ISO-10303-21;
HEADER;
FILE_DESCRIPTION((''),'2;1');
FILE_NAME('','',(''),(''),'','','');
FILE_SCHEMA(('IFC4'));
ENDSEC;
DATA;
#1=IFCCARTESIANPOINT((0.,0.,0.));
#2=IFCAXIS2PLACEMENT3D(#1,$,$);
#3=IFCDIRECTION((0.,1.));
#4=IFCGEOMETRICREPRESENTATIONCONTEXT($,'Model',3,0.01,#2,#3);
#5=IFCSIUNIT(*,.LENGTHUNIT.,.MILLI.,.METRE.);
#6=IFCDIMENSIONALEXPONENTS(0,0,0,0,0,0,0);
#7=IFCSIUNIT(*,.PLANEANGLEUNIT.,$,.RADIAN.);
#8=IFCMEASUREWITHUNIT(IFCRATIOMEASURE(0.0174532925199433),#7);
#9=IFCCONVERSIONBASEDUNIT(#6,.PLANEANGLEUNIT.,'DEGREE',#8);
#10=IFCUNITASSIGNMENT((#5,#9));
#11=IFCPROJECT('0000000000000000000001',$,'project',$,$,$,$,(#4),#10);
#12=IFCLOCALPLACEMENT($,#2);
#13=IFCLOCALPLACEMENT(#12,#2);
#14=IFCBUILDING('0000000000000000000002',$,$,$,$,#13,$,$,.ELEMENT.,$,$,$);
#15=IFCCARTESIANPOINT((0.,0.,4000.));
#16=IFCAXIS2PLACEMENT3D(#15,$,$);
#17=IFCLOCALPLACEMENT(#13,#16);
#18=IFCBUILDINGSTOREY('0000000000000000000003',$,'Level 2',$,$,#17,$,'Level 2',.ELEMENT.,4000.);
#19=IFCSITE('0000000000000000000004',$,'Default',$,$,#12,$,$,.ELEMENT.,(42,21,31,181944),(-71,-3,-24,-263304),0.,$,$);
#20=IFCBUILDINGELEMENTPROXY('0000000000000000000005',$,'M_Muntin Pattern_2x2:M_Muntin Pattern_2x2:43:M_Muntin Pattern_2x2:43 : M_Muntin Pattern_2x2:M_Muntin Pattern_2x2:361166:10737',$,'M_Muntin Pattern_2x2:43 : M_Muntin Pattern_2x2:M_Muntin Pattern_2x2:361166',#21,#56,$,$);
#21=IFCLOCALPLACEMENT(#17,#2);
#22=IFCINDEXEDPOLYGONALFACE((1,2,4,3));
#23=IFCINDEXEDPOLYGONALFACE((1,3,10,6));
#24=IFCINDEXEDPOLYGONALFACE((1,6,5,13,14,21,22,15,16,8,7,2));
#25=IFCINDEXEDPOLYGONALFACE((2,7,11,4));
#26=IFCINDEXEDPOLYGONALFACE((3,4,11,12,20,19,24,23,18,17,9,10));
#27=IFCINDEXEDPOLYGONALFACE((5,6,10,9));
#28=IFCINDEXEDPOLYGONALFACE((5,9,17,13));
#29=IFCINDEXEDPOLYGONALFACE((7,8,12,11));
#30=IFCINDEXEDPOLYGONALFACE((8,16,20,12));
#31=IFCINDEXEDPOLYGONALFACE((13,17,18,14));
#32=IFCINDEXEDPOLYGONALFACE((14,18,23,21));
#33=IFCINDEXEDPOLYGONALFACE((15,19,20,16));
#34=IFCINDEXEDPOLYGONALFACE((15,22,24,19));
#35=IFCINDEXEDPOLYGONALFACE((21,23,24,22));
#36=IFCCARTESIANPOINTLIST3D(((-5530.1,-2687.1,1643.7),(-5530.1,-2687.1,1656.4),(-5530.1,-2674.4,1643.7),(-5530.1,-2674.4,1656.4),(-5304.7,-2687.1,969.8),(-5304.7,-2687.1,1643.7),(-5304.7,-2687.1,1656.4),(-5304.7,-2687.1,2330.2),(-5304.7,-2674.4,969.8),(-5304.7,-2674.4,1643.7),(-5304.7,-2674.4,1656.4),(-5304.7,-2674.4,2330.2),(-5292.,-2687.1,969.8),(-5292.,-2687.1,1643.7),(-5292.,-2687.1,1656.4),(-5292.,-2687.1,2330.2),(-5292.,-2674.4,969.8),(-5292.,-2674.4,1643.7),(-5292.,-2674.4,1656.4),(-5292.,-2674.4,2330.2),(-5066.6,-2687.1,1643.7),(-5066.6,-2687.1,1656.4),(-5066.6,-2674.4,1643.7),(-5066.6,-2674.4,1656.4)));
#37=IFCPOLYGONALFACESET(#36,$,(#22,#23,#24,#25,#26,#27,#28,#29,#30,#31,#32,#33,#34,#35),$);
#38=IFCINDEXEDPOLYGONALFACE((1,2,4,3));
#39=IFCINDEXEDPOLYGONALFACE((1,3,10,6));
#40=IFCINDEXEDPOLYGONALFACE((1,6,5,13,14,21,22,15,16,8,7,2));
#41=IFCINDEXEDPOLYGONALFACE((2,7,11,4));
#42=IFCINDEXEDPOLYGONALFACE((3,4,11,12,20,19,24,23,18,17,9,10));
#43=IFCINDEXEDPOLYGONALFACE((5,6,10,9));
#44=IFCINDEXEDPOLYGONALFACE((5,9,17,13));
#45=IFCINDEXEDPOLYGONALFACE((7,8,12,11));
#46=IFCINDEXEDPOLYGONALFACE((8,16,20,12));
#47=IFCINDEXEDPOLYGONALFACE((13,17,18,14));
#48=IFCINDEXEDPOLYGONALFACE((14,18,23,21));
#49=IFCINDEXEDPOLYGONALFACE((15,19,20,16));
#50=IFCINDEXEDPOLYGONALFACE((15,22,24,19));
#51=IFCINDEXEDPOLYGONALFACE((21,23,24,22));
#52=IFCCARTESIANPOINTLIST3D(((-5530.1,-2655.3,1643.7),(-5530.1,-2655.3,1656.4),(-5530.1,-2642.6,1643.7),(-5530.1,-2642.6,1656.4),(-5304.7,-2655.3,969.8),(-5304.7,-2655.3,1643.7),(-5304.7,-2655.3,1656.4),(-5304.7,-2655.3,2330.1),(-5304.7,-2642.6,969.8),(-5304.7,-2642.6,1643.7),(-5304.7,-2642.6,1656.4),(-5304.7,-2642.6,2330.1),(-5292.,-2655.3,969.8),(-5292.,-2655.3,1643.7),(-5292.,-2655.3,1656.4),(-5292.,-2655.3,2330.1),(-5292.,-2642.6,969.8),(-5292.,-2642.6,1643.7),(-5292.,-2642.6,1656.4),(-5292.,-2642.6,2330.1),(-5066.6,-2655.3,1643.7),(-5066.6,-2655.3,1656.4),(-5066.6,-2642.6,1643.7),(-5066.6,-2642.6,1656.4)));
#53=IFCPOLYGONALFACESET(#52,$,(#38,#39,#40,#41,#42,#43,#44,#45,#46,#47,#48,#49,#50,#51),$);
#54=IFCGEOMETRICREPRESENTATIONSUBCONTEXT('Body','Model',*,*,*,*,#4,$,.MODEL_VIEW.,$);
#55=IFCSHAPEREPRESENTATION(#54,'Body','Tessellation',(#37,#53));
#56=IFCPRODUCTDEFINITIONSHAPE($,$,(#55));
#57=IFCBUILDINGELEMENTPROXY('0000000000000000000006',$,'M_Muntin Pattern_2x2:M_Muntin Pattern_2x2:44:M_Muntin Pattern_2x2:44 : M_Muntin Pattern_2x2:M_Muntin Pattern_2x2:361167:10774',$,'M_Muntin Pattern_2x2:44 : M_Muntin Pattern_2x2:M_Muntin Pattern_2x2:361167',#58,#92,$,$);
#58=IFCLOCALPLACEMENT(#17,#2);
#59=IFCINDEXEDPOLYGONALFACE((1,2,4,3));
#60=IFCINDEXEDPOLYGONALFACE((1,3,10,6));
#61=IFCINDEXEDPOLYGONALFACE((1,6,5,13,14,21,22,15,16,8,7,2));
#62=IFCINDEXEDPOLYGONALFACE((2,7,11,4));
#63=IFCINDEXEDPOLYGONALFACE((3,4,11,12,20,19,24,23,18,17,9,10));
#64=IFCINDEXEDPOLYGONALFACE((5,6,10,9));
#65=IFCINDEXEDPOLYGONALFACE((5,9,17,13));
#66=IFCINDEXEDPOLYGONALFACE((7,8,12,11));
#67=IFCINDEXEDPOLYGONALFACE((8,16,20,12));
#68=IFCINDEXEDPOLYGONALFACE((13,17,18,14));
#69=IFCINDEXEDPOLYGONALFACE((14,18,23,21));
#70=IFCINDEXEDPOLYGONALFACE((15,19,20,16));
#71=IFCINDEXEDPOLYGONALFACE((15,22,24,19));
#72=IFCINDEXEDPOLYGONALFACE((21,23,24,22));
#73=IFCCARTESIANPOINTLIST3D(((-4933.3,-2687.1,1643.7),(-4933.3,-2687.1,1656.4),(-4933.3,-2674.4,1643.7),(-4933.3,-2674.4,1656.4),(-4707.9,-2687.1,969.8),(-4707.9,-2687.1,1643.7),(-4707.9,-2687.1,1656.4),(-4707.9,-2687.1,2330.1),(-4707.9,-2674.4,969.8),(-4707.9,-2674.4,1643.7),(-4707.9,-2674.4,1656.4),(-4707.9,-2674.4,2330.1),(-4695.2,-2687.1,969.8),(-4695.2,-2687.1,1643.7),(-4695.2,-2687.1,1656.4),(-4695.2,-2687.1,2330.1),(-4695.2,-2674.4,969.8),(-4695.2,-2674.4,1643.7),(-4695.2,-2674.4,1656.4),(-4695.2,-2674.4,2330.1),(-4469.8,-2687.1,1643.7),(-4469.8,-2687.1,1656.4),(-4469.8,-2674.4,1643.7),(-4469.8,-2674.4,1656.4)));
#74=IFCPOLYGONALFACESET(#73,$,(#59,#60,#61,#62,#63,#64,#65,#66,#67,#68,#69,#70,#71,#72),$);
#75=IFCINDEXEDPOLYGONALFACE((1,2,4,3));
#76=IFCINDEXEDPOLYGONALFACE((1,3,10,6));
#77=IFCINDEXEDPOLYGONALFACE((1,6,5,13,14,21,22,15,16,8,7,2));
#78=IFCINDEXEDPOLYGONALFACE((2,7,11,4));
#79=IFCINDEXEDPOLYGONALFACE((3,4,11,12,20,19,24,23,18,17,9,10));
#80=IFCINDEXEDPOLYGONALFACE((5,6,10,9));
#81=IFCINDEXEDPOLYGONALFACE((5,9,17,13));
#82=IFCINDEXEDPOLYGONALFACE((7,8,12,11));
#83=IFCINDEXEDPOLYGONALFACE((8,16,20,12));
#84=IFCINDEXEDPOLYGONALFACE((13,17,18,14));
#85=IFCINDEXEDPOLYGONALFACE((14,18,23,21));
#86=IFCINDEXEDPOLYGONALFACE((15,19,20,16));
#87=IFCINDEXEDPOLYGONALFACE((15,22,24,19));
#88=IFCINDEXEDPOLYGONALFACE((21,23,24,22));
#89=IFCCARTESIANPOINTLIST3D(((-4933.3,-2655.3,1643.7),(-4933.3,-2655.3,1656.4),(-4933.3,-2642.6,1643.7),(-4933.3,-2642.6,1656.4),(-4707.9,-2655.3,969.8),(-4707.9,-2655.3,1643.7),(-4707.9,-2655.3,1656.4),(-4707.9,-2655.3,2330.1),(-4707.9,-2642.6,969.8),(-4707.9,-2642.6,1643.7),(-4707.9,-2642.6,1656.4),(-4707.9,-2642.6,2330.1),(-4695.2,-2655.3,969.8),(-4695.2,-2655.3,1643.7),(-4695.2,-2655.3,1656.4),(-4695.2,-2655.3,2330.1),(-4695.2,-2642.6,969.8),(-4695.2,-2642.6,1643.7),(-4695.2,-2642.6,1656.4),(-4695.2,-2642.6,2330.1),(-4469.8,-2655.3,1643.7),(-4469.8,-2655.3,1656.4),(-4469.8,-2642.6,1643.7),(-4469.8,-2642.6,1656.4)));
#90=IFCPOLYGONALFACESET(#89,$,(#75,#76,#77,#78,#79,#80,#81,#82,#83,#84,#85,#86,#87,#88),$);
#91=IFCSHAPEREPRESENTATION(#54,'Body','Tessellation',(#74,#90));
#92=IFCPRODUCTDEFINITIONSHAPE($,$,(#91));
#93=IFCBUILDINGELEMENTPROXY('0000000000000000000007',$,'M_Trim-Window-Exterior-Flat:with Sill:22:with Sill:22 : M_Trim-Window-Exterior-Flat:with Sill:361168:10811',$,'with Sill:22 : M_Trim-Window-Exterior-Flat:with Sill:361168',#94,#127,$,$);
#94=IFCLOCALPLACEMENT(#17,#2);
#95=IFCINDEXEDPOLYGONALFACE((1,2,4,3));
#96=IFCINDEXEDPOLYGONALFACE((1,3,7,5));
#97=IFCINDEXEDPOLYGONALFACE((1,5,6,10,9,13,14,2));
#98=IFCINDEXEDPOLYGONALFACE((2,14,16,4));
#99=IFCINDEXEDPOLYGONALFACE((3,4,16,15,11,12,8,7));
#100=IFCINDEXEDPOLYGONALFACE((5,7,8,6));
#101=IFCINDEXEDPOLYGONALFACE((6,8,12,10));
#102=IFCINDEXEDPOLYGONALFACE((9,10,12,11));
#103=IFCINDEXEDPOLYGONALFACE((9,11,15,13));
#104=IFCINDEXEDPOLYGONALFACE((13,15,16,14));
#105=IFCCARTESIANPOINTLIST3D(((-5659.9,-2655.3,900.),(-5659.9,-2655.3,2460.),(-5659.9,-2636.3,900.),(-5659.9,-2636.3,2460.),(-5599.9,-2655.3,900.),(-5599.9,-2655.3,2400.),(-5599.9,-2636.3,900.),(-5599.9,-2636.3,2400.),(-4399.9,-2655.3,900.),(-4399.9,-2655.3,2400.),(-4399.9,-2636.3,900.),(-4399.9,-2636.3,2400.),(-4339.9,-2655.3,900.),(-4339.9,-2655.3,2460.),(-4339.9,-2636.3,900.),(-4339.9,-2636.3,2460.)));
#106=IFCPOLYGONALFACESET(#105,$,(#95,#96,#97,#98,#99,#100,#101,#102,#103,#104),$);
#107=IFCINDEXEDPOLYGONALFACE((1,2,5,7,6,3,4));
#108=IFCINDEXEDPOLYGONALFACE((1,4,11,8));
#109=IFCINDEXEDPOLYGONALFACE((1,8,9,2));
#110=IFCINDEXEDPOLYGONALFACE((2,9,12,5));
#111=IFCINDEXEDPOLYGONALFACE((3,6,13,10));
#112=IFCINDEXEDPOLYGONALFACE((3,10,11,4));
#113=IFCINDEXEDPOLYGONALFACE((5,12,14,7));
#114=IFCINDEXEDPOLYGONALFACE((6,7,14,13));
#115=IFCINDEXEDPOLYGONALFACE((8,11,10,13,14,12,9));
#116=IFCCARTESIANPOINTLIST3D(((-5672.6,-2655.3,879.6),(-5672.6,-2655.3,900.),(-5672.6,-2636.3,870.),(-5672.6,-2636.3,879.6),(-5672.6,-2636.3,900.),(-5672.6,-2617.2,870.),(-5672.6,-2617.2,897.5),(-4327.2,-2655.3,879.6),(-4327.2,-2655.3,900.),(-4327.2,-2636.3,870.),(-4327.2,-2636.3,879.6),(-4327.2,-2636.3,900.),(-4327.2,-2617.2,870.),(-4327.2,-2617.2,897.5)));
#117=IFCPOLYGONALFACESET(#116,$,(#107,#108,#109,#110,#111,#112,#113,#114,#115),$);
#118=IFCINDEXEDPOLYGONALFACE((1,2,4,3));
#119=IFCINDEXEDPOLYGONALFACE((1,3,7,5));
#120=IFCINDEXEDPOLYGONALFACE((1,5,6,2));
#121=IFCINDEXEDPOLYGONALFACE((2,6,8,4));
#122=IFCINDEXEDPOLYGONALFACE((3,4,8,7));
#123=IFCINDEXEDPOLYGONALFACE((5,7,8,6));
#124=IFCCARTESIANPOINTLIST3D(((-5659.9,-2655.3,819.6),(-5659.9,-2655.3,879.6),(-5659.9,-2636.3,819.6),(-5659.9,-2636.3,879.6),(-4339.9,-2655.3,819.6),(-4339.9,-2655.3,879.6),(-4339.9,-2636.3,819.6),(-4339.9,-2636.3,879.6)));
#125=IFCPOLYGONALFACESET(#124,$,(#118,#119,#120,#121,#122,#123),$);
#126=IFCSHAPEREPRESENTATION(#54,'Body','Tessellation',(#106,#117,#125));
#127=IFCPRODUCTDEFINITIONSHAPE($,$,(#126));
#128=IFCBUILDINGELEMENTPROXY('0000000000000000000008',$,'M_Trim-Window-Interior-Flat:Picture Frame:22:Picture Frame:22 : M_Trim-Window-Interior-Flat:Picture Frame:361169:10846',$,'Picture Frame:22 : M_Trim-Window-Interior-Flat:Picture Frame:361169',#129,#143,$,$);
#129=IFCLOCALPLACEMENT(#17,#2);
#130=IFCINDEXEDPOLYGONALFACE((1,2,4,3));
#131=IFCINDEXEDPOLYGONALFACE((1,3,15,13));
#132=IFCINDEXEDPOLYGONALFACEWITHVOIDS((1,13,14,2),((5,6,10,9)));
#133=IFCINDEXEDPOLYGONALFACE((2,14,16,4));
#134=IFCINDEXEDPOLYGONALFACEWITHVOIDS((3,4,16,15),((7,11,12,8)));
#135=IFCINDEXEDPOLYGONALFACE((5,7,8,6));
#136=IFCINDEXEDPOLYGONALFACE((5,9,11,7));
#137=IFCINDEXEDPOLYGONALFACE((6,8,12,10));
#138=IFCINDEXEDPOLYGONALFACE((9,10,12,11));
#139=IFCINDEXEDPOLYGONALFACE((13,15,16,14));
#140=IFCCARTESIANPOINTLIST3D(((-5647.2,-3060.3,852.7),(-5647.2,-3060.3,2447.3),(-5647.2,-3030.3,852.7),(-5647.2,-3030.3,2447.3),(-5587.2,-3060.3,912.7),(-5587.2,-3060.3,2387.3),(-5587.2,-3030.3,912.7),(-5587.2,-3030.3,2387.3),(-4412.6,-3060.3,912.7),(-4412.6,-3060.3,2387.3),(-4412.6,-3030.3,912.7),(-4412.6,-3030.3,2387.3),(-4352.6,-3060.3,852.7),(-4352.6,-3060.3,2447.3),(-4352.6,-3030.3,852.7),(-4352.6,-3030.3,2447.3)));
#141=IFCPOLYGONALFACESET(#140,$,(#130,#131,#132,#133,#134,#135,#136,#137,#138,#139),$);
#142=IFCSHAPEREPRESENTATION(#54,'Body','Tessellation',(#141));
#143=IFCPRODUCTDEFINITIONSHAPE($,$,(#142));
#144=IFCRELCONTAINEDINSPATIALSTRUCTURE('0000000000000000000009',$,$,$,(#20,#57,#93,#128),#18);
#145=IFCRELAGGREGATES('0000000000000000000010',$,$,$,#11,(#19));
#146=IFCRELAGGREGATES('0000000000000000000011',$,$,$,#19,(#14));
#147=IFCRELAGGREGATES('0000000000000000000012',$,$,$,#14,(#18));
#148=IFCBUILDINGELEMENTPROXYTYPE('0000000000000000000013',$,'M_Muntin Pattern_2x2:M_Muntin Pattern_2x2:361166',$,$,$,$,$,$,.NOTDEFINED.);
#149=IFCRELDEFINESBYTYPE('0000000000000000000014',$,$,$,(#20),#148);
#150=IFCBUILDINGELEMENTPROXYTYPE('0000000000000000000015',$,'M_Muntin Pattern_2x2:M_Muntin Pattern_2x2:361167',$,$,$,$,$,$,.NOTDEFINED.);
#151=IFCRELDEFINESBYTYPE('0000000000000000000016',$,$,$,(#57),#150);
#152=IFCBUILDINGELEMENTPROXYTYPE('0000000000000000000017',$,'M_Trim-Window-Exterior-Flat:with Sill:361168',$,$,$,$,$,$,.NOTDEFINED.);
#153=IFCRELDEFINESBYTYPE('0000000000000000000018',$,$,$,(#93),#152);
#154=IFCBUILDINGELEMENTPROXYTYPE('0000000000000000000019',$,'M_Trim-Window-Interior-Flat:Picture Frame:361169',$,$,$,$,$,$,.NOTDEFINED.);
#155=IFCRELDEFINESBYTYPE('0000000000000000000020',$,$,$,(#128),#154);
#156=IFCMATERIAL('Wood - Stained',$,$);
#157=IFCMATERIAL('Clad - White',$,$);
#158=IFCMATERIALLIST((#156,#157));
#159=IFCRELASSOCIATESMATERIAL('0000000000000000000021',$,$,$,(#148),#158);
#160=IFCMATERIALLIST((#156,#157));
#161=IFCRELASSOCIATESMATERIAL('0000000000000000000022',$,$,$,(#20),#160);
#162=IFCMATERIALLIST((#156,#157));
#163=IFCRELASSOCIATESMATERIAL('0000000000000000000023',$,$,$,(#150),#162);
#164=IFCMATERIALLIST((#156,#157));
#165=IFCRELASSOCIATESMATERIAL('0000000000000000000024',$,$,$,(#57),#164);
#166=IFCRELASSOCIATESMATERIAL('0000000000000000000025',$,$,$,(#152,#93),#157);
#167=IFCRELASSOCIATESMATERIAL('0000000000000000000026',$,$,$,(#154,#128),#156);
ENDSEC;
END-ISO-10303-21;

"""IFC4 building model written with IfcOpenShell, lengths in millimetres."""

from ifc_helpers import new_model, entity, si_unit, converted_unit, direction, frame, frame_2d, origin, place, context, subcontext, project, spatial, polyline, rectangle, outline, extrude, source, transform, mapped, material, material_list, type_object, type_shapes, element, save


model = new_model("IFC4")

# Units and contexts
model_context = context("Model", 3, precision=0.01, world=origin(), true_north=direction((0.0, 1.0)))
body_context = subcontext(model_context, "Body", "Model", "MODEL_VIEW")
ifc_project = project(units=[si_unit("LENGTHUNIT", "METRE", prefix="MILLI"), converted_unit("PLANEANGLEUNIT", "DEGREE", entity("IfcRatioMeasure", 0.0174532925199433), si_unit("PLANEANGLEUNIT", "RADIAN"), dimensions=[0, 0, 0, 0, 0, 0, 0])], contexts=[model_context])

# Site, building, storey
site_placement = place(None, origin())
site = spatial("IfcSite", under=ifc_project, at=site_placement, Name="Default", CompositionType="ELEMENT", RefLatitude=(42, 21, 31, 181944), RefLongitude=(-71, -3, -24, -263304), RefElevation=0.0)
building_placement = place(site_placement, origin())
building = spatial("IfcBuilding", under=site, at=building_placement, CompositionType="ELEMENT")
storey_placement = place(building_placement, frame((0.0, 0.0, 4000.0)))
storey = spatial("IfcBuildingStorey", under=building, at=storey_placement, Name="Level 2", LongName="Level 2", CompositionType="ELEMENT", Elevation=4000.0)

# Building element proxies
ifc_material_1 = material(Name="Wood - Stained")
ifc_material_2 = material(Name="Clad - White")
ifc_material_list_1 = material_list([ifc_material_1, ifc_material_2])
ifc_material_list_2 = material_list([ifc_material_1, ifc_material_2])
building_element_proxy_type_1 = type_object("IfcBuildingElementProxyType", Name="M_Muntin Pattern_2x2:M_Muntin Pattern_2x2:361166", PredefinedType="NOTDEFINED", material=ifc_material_list_2)
shared_shape_1 = source(origin(), body_context, "Body", "SweptSolid", [
    extrude(outline(polyline([(-6.4, -680.2), (6.3, -680.2), (6.3, -6.4), (231.7, -6.4), (231.7, 6.3), (6.3, 6.3), (6.3, 680.2), (-6.4, 680.2), (-6.4, 6.3), (-231.7, 6.3), (-231.7, -6.4), (-6.4, -6.4), (-6.4, -680.2)])), frame((-5298.4, -2687.1, 5650.0), z_axis=(0.0, 1.0, 0.0), x_axis=(1.0, 0.0, 0.0)), (0.0, 0.0, 1.0), 12.7),
    extrude(outline(polyline([(-6.4, -680.1), (6.3, -680.1), (6.3, -6.4), (231.7, -6.4), (231.7, 6.3), (6.3, 6.3), (6.3, 680.2), (-6.4, 680.2), (-6.4, 6.3), (-231.7, 6.3), (-231.7, -6.4), (-6.4, -6.4), (-6.4, -680.1)])), frame((-5298.4, -2655.3, 5650.0), z_axis=(0.0, 1.0, 0.0), x_axis=(1.0, 0.0, 0.0)), (0.0, 0.0, 1.0), 12.7),
])
type_shapes(building_element_proxy_type_1, [shared_shape_1])
proxy_1_placement = place(storey_placement, frame((0.0, 0.0, -4000.0)))
element("IfcBuildingElementProxy", 1, at=proxy_1_placement, inside=storey, type_object=building_element_proxy_type_1, material=ifc_material_list_1, Name="M_Muntin Pattern_2x2:M_Muntin Pattern_2x2:43:M_Muntin Pattern_2x2:43 : M_Muntin Pattern_2x2:M_Muntin Pattern_2x2:361166:10737", ObjectType="M_Muntin Pattern_2x2:43 : M_Muntin Pattern_2x2:M_Muntin Pattern_2x2:361166", context=body_context, shape_type="MappedRepresentation", body=[
    mapped(shared_shape_1, transform((0.0, 0.0, 0.0), scale=1.0)),
])
ifc_material_list_3 = material_list([ifc_material_1, ifc_material_2])
ifc_material_list_4 = material_list([ifc_material_1, ifc_material_2])
building_element_proxy_type_2 = type_object("IfcBuildingElementProxyType", Name="M_Muntin Pattern_2x2:M_Muntin Pattern_2x2:361167", PredefinedType="NOTDEFINED", material=ifc_material_list_4)
shared_shape_2 = source(origin(), body_context, "Body", "SweptSolid", [
    extrude(outline(polyline([(-680.1, 6.4), (-680.1, -6.3), (-6.4, -6.3), (-6.4, -231.7), (6.3, -231.7), (6.3, -6.3), (680.2, -6.3), (680.2, 6.4), (6.3, 6.4), (6.3, 231.7), (-6.4, 231.7), (-6.4, 6.4), (-680.1, 6.4)])), frame((-4701.5, -2687.1, 5650.0), z_axis=(0.0, -1.0, 0.0), x_axis=(0.0, 0.0, -1.0)), (0.0, 0.0, -1.0), 12.7),
    extrude(outline(polyline([(-680.1, 6.4), (-680.1, -6.3), (-6.4, -6.3), (-6.4, -231.7), (6.3, -231.7), (6.3, -6.3), (680.2, -6.3), (680.2, 6.4), (6.3, 6.4), (6.3, 231.7), (-6.4, 231.7), (-6.4, 6.4), (-680.1, 6.4)])), frame((-4701.5, -2655.3, 5650.0), z_axis=(0.0, -1.0, 0.0), x_axis=(0.0, 0.0, -1.0)), (0.0, 0.0, -1.0), 12.7),
])
type_shapes(building_element_proxy_type_2, [shared_shape_2])
proxy_2_placement = place(storey_placement, frame((0.0, 0.0, -4000.0)))
element("IfcBuildingElementProxy", 2, at=proxy_2_placement, inside=storey, type_object=building_element_proxy_type_2, material=ifc_material_list_3, Name="M_Muntin Pattern_2x2:M_Muntin Pattern_2x2:44:M_Muntin Pattern_2x2:44 : M_Muntin Pattern_2x2:M_Muntin Pattern_2x2:361167:10774", ObjectType="M_Muntin Pattern_2x2:44 : M_Muntin Pattern_2x2:M_Muntin Pattern_2x2:361167", context=body_context, shape_type="MappedRepresentation", body=[
    mapped(shared_shape_2, transform((0.0, 0.0, 0.0), scale=1.0)),
])
building_element_proxy_type_3 = type_object("IfcBuildingElementProxyType", Name="M_Trim-Window-Exterior-Flat:with Sill:361168", PredefinedType="NOTDEFINED", material=ifc_material_2)
shared_shape_3 = source(origin(), body_context, "Body", "SweptSolid", [
    extrude(outline(polyline([(-660.0, -765.0), (-600.0, -765.0), (-600.0, 735.0), (600.0, 735.0), (600.0, -765.0), (660.0, -765.0), (660.0, 795.0), (-660.0, 795.0), (-660.0, -765.0)])), frame((-4999.9, -2655.3, 5665.0), z_axis=(0.0, 1.0, 0.0), x_axis=(-1.0, 0.0, 0.0)), (0.0, 0.0, 1.0), 19.1),
    extrude(outline(polyline([(0.0, -15.2), (19.0, -15.2), (19.0, 12.3), (0.0, 14.8), (-19.0, 14.8), (-19.0, -5.7), (0.0, -5.7), (0.0, -15.2)])), frame((-5672.6, -2636.3, 4885.2), z_axis=(1.0, 0.0, 0.0), x_axis=(0.0, 1.0, 0.0)), (0.0, 0.0, 1.0), 1345.4),
    extrude(rectangle(XDim=19.1, YDim=1320.0, at=frame_2d((0.0, 0.0), x_axis=(1.0, 0.0))), frame((-4999.9, -2645.8, 4819.6), z_axis=(0.0, 0.0, 1.0), x_axis=(0.0, -1.0, 0.0)), (0.0, 0.0, 1.0), 60.0),
])
type_shapes(building_element_proxy_type_3, [shared_shape_3])
proxy_3_placement = place(storey_placement, frame((0.0, 0.0, -4000.0)))
element("IfcBuildingElementProxy", 3, at=proxy_3_placement, inside=storey, type_object=building_element_proxy_type_3, material=ifc_material_2, Name="M_Trim-Window-Exterior-Flat:with Sill:22:with Sill:22 : M_Trim-Window-Exterior-Flat:with Sill:361168:10811", ObjectType="with Sill:22 : M_Trim-Window-Exterior-Flat:with Sill:361168", context=body_context, shape_type="MappedRepresentation", body=[
    mapped(shared_shape_3, transform((0.0, 0.0, 0.0), scale=1.0)),
])
building_element_proxy_type_4 = type_object("IfcBuildingElementProxyType", Name="M_Trim-Window-Interior-Flat:Picture Frame:361169", PredefinedType="NOTDEFINED", material=ifc_material_1)
shared_shape_4 = source(origin(), body_context, "Body", "SweptSolid", [
    extrude(outline(polyline([(-647.3, -797.3), (647.3, -797.3), (647.3, 797.3), (-647.3, 797.3), (-647.3, -797.3)]), holes=[polyline([(587.3, 737.3), (587.3, -737.3), (-587.3, -737.3), (-587.3, 737.3), (587.3, 737.3)])]), frame((-4999.9, -3060.3, 5650.0), z_axis=(0.0, 1.0, 0.0), x_axis=(1.0, 0.0, 0.0)), (0.0, 0.0, 1.0), 30.0),
])
type_shapes(building_element_proxy_type_4, [shared_shape_4])
proxy_4_placement = place(storey_placement, frame((0.0, 0.0, -4000.0)))
element("IfcBuildingElementProxy", 4, at=proxy_4_placement, inside=storey, type_object=building_element_proxy_type_4, material=ifc_material_1, Name="M_Trim-Window-Interior-Flat:Picture Frame:22:Picture Frame:22 : M_Trim-Window-Interior-Flat:Picture Frame:361169:10846", ObjectType="Picture Frame:22 : M_Trim-Window-Interior-Flat:Picture Frame:361169", context=body_context, shape_type="MappedRepresentation", body=[
    mapped(shared_shape_4, transform((0.0, 0.0, 0.0), scale=1.0)),
])

save(model, "model.ifc")
